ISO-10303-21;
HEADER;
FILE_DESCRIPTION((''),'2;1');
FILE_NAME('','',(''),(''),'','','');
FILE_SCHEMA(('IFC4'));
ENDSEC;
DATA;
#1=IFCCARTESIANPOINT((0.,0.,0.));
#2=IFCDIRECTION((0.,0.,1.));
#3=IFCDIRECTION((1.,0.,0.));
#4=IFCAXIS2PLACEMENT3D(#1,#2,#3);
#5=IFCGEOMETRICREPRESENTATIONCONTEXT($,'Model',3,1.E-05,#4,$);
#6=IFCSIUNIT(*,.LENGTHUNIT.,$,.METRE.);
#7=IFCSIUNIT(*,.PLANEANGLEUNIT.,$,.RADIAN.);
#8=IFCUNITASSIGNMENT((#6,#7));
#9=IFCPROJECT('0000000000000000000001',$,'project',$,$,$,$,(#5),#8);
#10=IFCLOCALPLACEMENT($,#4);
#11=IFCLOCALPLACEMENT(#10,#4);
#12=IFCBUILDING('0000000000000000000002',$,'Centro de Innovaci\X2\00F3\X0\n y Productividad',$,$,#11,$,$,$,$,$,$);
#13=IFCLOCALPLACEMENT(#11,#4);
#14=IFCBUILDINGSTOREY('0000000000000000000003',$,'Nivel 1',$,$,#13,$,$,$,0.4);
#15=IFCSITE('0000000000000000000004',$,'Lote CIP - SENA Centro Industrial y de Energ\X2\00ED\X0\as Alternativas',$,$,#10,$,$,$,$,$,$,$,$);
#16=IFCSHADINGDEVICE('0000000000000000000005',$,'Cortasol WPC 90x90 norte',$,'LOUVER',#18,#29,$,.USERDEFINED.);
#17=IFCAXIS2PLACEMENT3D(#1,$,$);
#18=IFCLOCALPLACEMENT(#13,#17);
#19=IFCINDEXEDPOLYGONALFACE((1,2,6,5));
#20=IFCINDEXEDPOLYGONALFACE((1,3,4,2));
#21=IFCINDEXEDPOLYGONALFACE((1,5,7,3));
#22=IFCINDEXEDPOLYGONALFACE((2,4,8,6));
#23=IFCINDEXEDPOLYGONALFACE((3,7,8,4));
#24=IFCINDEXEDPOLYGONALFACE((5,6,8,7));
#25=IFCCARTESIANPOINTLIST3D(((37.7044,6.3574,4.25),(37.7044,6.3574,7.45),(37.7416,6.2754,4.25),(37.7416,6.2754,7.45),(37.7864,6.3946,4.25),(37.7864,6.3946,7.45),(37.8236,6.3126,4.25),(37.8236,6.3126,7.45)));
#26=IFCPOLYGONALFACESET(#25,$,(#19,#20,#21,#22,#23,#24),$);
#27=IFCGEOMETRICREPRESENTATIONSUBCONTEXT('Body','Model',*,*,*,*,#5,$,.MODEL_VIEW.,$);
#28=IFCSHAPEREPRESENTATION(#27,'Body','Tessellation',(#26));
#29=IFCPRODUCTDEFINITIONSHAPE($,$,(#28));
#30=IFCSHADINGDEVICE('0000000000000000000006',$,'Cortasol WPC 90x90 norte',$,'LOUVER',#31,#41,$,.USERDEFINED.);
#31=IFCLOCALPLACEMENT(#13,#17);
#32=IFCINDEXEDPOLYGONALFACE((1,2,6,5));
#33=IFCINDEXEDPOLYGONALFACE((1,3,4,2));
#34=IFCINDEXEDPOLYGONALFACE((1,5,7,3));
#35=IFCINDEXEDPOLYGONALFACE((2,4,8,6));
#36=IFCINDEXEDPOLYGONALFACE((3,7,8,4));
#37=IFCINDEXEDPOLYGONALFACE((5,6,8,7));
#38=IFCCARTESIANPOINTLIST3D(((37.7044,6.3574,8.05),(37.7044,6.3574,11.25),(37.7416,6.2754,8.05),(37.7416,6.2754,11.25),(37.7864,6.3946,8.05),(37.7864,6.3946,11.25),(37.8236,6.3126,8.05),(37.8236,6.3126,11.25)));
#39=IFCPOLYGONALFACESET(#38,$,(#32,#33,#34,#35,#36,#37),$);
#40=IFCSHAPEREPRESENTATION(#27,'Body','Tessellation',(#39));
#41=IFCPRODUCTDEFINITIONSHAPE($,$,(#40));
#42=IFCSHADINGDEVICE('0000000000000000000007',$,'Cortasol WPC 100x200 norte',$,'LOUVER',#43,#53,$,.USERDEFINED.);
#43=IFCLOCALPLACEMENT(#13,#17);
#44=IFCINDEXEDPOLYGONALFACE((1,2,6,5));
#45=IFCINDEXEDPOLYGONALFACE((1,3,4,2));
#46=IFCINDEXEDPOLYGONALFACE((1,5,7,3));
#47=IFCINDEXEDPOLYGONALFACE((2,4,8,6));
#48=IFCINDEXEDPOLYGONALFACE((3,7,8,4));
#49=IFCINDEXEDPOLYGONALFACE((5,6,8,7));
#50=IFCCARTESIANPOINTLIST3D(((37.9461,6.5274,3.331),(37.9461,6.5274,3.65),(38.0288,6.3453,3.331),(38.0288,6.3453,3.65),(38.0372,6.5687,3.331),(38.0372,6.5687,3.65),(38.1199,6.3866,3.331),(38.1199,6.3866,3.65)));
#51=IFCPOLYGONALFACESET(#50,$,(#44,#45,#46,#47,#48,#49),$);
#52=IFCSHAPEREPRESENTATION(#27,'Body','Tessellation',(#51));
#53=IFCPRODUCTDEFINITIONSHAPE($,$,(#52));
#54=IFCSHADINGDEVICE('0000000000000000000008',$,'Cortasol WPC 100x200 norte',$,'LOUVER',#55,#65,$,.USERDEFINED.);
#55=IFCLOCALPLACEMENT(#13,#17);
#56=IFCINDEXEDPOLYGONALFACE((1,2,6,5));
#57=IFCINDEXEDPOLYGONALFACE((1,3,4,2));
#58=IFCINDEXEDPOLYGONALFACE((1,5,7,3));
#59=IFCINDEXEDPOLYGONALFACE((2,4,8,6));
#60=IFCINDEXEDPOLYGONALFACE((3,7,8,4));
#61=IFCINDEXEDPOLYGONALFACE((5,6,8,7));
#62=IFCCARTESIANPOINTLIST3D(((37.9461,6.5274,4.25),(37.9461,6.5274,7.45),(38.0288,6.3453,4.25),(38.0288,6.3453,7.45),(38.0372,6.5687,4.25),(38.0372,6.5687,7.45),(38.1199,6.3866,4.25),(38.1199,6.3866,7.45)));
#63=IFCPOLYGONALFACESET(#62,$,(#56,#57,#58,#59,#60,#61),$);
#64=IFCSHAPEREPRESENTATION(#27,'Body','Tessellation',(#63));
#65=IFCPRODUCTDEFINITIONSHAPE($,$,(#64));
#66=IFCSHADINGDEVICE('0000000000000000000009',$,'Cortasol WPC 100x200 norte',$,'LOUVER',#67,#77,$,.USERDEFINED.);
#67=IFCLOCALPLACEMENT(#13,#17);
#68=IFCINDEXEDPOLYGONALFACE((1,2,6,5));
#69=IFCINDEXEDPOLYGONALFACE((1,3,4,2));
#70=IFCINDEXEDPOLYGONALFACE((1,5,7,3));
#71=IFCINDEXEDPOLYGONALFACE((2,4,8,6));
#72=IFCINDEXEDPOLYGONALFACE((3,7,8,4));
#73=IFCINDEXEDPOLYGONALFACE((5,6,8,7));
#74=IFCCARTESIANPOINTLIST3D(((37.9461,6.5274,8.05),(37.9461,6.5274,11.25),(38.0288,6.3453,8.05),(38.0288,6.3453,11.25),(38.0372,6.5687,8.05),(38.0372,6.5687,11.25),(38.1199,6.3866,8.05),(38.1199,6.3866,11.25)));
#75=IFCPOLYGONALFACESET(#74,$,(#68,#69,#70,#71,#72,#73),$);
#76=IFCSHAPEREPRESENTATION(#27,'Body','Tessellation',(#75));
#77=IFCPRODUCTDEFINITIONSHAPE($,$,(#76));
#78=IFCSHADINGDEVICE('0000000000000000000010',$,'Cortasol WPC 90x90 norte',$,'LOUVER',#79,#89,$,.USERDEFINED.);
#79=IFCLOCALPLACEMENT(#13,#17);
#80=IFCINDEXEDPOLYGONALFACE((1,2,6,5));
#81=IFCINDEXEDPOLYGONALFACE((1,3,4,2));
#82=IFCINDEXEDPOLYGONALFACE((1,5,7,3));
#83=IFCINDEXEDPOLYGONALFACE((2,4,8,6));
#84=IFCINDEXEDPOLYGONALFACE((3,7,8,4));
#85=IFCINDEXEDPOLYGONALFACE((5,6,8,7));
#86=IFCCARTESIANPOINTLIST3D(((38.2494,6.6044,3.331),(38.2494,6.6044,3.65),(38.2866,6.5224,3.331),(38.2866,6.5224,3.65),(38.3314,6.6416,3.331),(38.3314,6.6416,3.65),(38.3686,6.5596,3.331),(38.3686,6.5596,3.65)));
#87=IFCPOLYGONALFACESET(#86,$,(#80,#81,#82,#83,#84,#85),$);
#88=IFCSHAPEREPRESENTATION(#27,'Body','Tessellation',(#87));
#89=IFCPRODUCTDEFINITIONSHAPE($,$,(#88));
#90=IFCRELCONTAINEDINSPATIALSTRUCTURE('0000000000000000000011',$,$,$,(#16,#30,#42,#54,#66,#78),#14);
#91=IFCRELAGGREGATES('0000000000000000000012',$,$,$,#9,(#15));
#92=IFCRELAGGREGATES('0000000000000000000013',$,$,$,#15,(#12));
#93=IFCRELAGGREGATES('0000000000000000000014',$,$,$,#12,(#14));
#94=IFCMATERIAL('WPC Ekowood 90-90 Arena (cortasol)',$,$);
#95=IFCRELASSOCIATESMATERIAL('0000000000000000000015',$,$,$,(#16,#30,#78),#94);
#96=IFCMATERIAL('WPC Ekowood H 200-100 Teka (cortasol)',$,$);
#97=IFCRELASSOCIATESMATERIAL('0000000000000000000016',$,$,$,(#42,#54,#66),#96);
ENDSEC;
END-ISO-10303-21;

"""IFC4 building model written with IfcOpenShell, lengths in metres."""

from ifc_helpers import new_model, si_unit, frame, origin_with_axes, place, context, subcontext, project, spatial, polyline, outline, extrude, material, element, save


model = new_model("IFC4")

# Units and contexts
model_context = context("Model", 3, precision=1e-05, world=origin_with_axes())
body_context = subcontext(model_context, "Body", "Model", "MODEL_VIEW")
ifc_project = project(units=[si_unit("LENGTHUNIT", "METRE"), si_unit("PLANEANGLEUNIT", "RADIAN")], contexts=[model_context])

# Site, building, storey
site_placement = place(None, origin_with_axes())
site = spatial("IfcSite", under=ifc_project, at=site_placement, Name="Lote CIP - SENA Centro Industrial y de Energías Alternativas")
building_placement = place(site_placement, origin_with_axes())
building = spatial("IfcBuilding", under=site, at=building_placement, Name="Centro de Innovación y Productividad")
storey_placement = place(building_placement, origin_with_axes())
storey = spatial("IfcBuildingStorey", under=building, at=storey_placement, Name="Nivel 1", Elevation=0.4)

# Shading devices
ifc_material_1 = material(Name="WPC Ekowood H 200-100 Teka (cortasol)")
ifc_material_2 = material(Name="WPC Ekowood 90-90 Arena (cortasol)")
shading_device_1_placement = place(storey_placement, origin_with_axes())
element("IfcShadingDevice", 1, at=shading_device_1_placement, inside=storey, material=ifc_material_2, Name="Cortasol WPC 90x90 norte", ObjectType="LOUVER", PredefinedType="USERDEFINED", context=body_context, shape_type="SweptSolid", body=[
    extrude(outline(polyline([(37.7416, 6.2754), (37.7044, 6.3574), (37.7864, 6.3946), (37.8236, 6.3126), (37.7416, 6.2754)])), frame((0.0, 0.0, 4.25)), (0.0, 0.0, 1.0), 3.2),
])
shading_device_2_placement = place(storey_placement, origin_with_axes())
element("IfcShadingDevice", 2, at=shading_device_2_placement, inside=storey, material=ifc_material_2, Name="Cortasol WPC 90x90 norte", ObjectType="LOUVER", PredefinedType="USERDEFINED", context=body_context, shape_type="SweptSolid", body=[
    extrude(outline(polyline([(37.7416, 6.2754), (37.7044, 6.3574), (37.7864, 6.3946), (37.8236, 6.3126), (37.7416, 6.2754)])), frame((0.0, 0.0, 8.05)), (0.0, 0.0, 1.0), 3.2),
])
shading_device_3_placement = place(storey_placement, origin_with_axes())
element("IfcShadingDevice", 3, at=shading_device_3_placement, inside=storey, material=ifc_material_1, Name="Cortasol WPC 100x200 norte", ObjectType="LOUVER", PredefinedType="USERDEFINED", context=body_context, shape_type="SweptSolid", body=[
    extrude(outline(polyline([(38.0288, 6.3453), (37.9461, 6.5274), (38.0372, 6.5687), (38.1199, 6.3866), (38.0288, 6.3453)])), frame((0.0, 0.0, 3.331)), (0.0, 0.0, 1.0), 0.319),
])
shading_device_4_placement = place(storey_placement, origin_with_axes())
element("IfcShadingDevice", 4, at=shading_device_4_placement, inside=storey, material=ifc_material_1, Name="Cortasol WPC 100x200 norte", ObjectType="LOUVER", PredefinedType="USERDEFINED", context=body_context, shape_type="SweptSolid", body=[
    extrude(outline(polyline([(38.0288, 6.3453), (37.9461, 6.5274), (38.0372, 6.5687), (38.1199, 6.3866), (38.0288, 6.3453)])), frame((0.0, 0.0, 4.25)), (0.0, 0.0, 1.0), 3.2),
])
shading_device_5_placement = place(storey_placement, origin_with_axes())
element("IfcShadingDevice", 5, at=shading_device_5_placement, inside=storey, material=ifc_material_1, Name="Cortasol WPC 100x200 norte", ObjectType="LOUVER", PredefinedType="USERDEFINED", context=body_context, shape_type="SweptSolid", body=[
    extrude(outline(polyline([(38.0288, 6.3453), (37.9461, 6.5274), (38.0372, 6.5687), (38.1199, 6.3866), (38.0288, 6.3453)])), frame((0.0, 0.0, 8.05)), (0.0, 0.0, 1.0), 3.2),
])
shading_device_6_placement = place(storey_placement, origin_with_axes())
element("IfcShadingDevice", 6, at=shading_device_6_placement, inside=storey, material=ifc_material_2, Name="Cortasol WPC 90x90 norte", ObjectType="LOUVER", PredefinedType="USERDEFINED", context=body_context, shape_type="SweptSolid", body=[
    extrude(outline(polyline([(38.2866, 6.5224), (38.2494, 6.6044), (38.3314, 6.6416), (38.3686, 6.5596), (38.2866, 6.5224)])), frame((0.0, 0.0, 3.331)), (0.0, 0.0, 1.0), 0.319),
])

save(model, "model.ifc")
